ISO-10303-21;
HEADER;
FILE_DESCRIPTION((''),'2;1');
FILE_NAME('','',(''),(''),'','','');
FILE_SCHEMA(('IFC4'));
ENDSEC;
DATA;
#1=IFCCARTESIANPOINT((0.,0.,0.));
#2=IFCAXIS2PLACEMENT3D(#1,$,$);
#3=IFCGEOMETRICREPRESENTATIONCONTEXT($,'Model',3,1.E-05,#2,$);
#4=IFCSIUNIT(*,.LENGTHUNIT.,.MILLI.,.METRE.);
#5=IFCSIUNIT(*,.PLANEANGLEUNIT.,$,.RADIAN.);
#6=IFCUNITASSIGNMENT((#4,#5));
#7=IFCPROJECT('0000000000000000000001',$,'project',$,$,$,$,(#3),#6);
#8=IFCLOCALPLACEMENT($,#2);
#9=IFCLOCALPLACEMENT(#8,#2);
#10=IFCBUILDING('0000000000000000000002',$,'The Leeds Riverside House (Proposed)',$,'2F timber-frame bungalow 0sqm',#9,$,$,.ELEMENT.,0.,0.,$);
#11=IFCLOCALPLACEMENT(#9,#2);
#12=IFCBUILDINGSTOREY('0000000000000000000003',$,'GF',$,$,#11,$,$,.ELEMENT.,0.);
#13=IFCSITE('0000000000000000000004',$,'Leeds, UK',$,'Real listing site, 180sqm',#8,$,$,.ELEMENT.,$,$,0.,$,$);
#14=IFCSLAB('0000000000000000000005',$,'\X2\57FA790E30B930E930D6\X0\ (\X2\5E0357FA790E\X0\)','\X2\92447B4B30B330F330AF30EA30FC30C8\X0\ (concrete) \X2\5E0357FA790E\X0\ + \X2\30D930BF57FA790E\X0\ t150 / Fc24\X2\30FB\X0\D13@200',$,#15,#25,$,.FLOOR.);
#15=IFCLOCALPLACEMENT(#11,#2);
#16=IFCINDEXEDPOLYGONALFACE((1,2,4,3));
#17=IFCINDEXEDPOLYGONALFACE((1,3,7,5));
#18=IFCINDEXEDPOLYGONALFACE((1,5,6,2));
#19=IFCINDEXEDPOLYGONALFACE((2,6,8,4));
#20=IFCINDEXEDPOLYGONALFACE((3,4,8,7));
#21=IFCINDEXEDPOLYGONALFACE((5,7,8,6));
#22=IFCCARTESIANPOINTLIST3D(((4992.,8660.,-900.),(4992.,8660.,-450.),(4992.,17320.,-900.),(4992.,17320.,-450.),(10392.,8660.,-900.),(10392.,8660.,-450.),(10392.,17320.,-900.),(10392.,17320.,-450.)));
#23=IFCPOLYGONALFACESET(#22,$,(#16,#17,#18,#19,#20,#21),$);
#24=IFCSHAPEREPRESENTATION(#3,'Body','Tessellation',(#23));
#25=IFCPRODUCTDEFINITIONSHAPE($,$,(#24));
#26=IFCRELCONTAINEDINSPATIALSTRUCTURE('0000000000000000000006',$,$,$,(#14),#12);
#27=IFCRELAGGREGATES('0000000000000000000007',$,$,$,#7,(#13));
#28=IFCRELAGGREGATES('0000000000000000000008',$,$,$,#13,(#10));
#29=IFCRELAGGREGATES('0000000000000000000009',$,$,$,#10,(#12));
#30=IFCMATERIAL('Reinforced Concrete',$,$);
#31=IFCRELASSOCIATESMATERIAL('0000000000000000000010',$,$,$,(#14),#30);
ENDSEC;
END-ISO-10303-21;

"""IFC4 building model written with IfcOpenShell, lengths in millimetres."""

from ifc_helpers import new_model, si_unit, frame, frame_2d, origin, place, context, project, spatial, rectangle, extrude, material, element, save


model = new_model("IFC4")

# Units and contexts
model_context = context("Model", 3, precision=1e-05, world=origin())
ifc_project = project(units=[si_unit("LENGTHUNIT", "METRE", prefix="MILLI"), si_unit("PLANEANGLEUNIT", "RADIAN")], contexts=[model_context])

# Site, building, storey
site_placement = place(None, origin())
site = spatial("IfcSite", under=ifc_project, at=site_placement, Name="Leeds, UK", ObjectType="Real listing site, 180sqm", CompositionType="ELEMENT", RefElevation=0.0)
building_placement = place(site_placement, origin())
building = spatial("IfcBuilding", under=site, at=building_placement, Name="The Leeds Riverside House (Proposed)", ObjectType="2F timber-frame bungalow 0sqm", CompositionType="ELEMENT", ElevationOfRefHeight=0.0, ElevationOfTerrain=0.0)
storey_placement = place(building_placement, origin())
storey = spatial("IfcBuildingStorey", under=building, at=storey_placement, Name="GF", CompositionType="ELEMENT", Elevation=0.0)

# Slab
ifc_material_1 = material(Name="Reinforced Concrete")
slab_1_placement = place(storey_placement, frame((2496.0, 4330.0, -450.0)))
element("IfcSlab", 1, at=slab_1_placement, inside=storey, material=ifc_material_1, Name="基礎スラブ (布基礎)", Description="鉄筋コンクリート (concrete) 布基礎 + ベタ基礎 t150 / Fc24・D13@200", PredefinedType="FLOOR", context=model_context, shape_type="SweptSolid", body=[
    extrude(rectangle(XDim=5400.0, YDim=8660.0, at=frame_2d((2700.0, 4330.0))), frame((2496.0, 4330.0, -450.0)), (0.0, 0.0, 1.0), 450.0),
])

save(model, "model.ifc")
